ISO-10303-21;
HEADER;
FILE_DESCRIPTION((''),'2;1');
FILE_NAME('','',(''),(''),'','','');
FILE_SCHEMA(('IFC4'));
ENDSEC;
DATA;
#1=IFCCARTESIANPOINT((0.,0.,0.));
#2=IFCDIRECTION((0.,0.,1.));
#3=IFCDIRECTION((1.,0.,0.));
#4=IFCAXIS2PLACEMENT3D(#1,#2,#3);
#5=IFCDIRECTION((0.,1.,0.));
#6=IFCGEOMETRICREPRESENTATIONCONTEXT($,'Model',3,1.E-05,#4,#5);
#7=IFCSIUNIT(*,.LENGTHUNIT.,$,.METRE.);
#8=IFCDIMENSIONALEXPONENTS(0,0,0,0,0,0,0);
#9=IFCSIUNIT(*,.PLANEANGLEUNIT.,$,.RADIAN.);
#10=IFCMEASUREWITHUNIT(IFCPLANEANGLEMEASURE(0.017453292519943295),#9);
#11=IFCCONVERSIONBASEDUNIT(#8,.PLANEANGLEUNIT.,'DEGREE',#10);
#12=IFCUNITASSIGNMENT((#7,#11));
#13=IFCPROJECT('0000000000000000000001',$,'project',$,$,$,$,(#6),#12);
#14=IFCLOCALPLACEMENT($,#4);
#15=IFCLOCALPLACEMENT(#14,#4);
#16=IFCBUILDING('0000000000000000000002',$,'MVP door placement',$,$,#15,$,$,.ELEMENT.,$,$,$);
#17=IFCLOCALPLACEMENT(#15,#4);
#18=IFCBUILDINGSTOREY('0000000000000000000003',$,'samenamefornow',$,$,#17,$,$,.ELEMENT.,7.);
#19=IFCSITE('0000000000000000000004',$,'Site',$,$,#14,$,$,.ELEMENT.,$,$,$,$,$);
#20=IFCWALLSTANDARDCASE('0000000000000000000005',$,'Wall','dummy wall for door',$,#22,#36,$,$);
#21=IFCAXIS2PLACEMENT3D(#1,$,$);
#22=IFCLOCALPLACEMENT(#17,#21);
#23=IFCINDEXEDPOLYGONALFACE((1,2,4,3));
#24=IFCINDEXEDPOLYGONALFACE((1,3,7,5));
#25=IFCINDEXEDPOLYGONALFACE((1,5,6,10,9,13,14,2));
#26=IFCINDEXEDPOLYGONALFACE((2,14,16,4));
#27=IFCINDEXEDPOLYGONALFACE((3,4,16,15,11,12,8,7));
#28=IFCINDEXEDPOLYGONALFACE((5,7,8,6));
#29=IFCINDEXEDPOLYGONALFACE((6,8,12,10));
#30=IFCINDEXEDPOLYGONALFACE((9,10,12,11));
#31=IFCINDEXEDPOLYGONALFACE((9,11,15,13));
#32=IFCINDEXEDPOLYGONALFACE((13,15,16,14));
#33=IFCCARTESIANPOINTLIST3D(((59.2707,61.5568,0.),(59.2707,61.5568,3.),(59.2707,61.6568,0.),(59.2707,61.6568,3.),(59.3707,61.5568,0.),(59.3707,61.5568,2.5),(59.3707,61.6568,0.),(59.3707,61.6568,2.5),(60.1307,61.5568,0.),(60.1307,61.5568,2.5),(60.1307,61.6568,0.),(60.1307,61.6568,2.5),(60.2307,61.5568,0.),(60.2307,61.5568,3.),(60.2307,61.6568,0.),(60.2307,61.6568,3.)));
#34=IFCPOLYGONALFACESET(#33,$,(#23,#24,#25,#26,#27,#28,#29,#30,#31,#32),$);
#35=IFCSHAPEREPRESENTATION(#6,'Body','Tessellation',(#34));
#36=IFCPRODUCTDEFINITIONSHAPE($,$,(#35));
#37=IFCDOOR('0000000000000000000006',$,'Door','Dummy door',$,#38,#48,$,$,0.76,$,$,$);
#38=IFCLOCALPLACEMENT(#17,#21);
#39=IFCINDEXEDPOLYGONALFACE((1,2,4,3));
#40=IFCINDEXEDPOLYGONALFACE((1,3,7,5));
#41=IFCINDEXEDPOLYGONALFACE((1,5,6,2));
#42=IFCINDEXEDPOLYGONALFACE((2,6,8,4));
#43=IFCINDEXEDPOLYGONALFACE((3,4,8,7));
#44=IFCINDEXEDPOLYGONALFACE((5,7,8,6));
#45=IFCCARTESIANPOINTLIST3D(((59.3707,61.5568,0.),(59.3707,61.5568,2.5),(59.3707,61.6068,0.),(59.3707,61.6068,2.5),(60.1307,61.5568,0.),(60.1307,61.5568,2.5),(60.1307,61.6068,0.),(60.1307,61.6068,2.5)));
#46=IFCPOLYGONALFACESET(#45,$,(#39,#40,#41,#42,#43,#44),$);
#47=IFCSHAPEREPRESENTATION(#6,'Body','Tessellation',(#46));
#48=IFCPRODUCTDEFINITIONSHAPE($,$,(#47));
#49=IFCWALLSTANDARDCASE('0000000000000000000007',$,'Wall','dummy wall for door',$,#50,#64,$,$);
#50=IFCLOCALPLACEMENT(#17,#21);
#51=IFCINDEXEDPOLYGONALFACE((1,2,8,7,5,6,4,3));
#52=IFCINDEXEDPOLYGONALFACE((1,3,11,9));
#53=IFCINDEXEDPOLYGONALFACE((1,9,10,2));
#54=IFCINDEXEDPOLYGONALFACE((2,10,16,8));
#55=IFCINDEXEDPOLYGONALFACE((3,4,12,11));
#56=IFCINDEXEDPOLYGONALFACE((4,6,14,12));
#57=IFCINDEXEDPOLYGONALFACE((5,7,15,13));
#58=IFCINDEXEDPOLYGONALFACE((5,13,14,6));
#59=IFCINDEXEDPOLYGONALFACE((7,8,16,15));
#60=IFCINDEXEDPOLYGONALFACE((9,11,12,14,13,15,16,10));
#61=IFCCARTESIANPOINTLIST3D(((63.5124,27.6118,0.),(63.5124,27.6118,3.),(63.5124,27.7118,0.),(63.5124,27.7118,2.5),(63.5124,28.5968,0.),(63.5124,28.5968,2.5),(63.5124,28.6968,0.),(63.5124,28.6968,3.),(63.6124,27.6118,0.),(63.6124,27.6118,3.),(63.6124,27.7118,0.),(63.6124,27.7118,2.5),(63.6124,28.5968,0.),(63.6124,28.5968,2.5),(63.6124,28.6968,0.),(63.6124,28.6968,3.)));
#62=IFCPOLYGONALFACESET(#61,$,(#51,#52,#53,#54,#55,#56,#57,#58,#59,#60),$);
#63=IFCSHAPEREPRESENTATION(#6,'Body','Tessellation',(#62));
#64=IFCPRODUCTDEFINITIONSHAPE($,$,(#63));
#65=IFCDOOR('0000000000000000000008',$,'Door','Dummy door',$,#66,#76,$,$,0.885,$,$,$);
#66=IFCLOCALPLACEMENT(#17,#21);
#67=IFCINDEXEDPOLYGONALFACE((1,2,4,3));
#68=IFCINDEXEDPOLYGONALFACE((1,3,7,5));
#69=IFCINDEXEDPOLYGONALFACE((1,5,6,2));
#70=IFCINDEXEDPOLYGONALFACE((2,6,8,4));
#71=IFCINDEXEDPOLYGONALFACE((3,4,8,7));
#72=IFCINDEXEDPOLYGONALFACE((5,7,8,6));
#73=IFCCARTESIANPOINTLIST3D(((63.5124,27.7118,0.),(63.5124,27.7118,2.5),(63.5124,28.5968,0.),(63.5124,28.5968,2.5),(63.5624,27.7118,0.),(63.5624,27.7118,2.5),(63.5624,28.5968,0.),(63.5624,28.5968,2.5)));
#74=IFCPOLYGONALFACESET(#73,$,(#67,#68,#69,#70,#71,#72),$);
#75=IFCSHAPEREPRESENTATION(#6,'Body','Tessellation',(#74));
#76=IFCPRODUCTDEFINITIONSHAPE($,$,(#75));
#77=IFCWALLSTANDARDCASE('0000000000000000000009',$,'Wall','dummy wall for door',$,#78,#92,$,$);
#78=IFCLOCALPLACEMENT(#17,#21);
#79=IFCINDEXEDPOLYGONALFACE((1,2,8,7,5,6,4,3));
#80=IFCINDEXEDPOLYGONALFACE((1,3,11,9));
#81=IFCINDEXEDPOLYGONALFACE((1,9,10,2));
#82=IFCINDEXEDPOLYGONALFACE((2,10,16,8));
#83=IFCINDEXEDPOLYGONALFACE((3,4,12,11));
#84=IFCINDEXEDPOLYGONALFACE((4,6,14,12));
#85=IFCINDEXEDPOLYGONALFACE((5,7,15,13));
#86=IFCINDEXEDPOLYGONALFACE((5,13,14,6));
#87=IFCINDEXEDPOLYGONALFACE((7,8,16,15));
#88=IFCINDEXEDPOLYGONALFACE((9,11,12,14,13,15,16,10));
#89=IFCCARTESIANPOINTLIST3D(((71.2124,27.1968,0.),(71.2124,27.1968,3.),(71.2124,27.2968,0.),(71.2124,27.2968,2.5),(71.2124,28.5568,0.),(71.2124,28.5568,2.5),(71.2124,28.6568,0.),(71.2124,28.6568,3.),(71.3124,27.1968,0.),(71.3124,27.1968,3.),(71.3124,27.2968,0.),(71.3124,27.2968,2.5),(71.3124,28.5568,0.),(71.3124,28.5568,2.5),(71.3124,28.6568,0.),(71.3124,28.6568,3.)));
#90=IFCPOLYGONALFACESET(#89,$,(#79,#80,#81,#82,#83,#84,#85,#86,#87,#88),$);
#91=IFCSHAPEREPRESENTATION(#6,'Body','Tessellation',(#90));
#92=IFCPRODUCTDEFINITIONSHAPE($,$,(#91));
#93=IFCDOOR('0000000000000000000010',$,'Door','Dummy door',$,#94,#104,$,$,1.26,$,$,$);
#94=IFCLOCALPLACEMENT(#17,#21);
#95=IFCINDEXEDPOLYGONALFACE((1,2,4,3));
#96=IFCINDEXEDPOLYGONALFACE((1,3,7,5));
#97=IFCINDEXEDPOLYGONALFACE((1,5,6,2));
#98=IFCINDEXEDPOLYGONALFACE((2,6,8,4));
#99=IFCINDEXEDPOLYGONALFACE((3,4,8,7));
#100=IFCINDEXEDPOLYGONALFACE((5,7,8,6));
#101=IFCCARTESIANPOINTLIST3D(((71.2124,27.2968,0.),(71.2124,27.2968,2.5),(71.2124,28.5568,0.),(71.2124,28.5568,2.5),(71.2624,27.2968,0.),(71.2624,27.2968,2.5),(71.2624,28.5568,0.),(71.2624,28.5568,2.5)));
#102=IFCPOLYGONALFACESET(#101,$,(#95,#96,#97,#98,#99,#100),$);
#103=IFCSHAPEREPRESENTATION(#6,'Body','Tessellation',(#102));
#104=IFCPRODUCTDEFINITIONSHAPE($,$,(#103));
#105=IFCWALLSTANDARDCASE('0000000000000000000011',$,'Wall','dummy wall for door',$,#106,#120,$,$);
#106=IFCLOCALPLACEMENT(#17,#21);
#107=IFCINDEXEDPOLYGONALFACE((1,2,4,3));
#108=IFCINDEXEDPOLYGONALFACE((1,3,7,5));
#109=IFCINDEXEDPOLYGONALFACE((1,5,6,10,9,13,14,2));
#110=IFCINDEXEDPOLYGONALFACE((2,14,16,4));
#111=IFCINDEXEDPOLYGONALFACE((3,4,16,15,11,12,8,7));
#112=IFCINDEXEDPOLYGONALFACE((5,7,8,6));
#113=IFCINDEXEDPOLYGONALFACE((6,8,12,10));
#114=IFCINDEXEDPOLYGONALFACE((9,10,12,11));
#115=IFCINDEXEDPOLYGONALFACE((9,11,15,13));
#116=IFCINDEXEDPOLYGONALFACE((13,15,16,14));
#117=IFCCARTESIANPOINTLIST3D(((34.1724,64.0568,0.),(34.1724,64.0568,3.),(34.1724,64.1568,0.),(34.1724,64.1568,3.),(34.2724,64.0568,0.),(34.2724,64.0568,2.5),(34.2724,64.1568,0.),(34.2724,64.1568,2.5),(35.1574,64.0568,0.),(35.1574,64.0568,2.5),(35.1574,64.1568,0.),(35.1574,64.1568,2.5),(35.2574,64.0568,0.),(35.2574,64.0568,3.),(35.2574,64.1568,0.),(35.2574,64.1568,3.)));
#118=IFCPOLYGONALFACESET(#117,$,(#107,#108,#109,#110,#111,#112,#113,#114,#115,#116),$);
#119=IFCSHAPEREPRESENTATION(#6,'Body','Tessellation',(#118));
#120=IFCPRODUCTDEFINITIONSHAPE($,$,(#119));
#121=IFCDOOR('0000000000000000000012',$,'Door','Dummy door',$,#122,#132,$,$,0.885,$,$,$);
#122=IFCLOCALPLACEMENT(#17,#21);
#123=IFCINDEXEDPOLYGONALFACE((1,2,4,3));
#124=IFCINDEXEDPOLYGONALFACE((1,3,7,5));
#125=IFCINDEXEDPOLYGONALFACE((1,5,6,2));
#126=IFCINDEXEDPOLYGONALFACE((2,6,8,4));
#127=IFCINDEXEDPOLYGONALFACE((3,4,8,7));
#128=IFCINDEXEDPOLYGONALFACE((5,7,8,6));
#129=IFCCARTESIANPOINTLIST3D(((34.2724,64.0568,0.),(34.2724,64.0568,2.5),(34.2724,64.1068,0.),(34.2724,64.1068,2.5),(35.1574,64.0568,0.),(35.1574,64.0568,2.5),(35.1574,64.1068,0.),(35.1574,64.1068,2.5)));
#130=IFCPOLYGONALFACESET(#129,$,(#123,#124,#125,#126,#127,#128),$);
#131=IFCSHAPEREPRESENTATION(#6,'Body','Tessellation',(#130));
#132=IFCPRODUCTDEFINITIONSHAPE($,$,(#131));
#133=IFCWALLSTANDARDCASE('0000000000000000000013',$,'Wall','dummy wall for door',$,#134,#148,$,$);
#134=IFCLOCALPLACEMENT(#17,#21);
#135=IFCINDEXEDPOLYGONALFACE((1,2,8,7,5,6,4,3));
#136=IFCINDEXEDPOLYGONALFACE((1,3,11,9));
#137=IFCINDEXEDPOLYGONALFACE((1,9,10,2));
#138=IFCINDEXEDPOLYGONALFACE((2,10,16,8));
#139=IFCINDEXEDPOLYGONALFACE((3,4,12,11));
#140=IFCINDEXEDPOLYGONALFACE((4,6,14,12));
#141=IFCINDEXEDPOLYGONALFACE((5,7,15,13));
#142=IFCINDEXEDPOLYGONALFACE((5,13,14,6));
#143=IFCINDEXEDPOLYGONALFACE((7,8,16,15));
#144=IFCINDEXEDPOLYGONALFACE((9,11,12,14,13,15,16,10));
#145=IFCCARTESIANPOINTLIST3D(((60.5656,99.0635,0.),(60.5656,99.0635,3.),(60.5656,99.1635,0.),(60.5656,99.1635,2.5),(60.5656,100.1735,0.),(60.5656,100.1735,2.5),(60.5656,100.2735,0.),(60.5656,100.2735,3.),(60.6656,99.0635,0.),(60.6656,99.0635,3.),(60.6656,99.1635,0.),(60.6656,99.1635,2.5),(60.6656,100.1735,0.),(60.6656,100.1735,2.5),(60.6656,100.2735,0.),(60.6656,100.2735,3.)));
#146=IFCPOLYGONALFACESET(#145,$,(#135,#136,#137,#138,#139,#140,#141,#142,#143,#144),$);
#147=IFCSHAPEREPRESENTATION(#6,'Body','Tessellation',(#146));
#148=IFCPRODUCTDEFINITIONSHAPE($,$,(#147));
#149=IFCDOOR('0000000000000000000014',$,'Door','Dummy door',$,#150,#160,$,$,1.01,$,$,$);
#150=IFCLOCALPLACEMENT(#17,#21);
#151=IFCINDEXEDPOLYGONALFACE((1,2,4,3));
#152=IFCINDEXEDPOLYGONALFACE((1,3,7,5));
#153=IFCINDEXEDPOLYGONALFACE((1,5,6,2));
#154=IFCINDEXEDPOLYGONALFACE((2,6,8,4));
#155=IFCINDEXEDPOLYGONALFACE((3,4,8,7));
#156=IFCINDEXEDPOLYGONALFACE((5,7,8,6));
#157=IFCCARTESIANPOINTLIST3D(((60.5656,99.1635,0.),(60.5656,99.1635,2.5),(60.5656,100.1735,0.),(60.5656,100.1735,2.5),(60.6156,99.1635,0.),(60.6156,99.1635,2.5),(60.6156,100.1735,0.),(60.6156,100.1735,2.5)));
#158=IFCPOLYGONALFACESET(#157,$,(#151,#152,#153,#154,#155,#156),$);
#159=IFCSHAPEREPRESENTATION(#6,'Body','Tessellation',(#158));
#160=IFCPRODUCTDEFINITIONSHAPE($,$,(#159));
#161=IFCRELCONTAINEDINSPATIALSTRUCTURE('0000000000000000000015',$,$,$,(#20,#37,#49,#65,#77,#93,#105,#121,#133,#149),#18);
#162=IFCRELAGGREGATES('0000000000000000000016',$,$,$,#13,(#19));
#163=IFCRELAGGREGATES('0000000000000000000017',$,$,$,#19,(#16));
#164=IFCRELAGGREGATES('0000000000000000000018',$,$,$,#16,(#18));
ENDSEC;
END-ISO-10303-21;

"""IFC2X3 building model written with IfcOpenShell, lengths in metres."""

from ifc_helpers import new_model, entity, si_unit, converted_unit, direction, origin_with_axes, place, context, project, spatial, polyline, outline, extrude, element, fill, save


model = new_model("IFC2X3")

# Units and contexts
model_context = context("Model", 3, precision=1e-05, world=origin_with_axes(), true_north=direction((0.0, 1.0, 0.0)))
ifc_project = project(units=[si_unit("LENGTHUNIT", "METRE"), converted_unit("PLANEANGLEUNIT", "DEGREE", entity("IfcPlaneAngleMeasure", 0.017453292519943295), si_unit("PLANEANGLEUNIT", "RADIAN"), dimensions=[0, 0, 0, 0, 0, 0, 0])], contexts=[model_context])

# Site, building, storey
site_placement = place(None, origin_with_axes())
site = spatial("IfcSite", under=ifc_project, at=site_placement, Name="Site", CompositionType="ELEMENT")
building_placement = place(site_placement, origin_with_axes())
building = spatial("IfcBuilding", under=site, at=building_placement, Name="MVP door placement", CompositionType="ELEMENT")
storey_placement = place(building_placement, origin_with_axes())
storey = spatial("IfcBuildingStorey", under=building, at=storey_placement, Name="samenamefornow", CompositionType="ELEMENT", Elevation=7.0)

# Walls, openings, doors
wall_1_placement = place(storey_placement, origin_with_axes())
wall_1 = element("IfcWallStandardCase", 1, at=wall_1_placement, inside=storey, Name="Wall", Description="dummy wall for door", context=model_context, shape_type="SweptSolid", body=[
    extrude(outline(polyline([(60.2307, 61.5568, 0.0), (59.2707, 61.5568, 0.0), (59.2707, 61.6568, 0.0), (60.2307, 61.6568, 0.0), (60.2307, 61.5568, 0.0)])), origin_with_axes(), (0.0, 0.0, 1.0), 3.0),
])
opening_1_placement = place(wall_1_placement, origin_with_axes())
opening_1 = element("IfcOpeningElement", 2, at=opening_1_placement, cuts=wall_1, context=model_context, shape_type="SweptSolid", body=[
    extrude(outline(polyline([(60.1307, 61.5568, 0.0), (59.3707, 61.5568, 0.0), (59.3707, 61.6568, 0.0), (60.1307, 61.6568, 0.0), (60.1307, 61.5568, 0.0)])), origin_with_axes(), (0.0, 0.0, 1.0), 2.5),
])
door_1_placement = place(opening_1_placement, origin_with_axes())
door_1 = element("IfcDoor", 3, at=door_1_placement, inside=storey, Name="Door", Description="Dummy door", OverallWidth=0.76, context=model_context, shape_type="SweptSolid", body=[
    extrude(outline(polyline([(60.1307, 61.5568, 0.0), (59.3707, 61.5568, 0.0), (59.3707, 61.6068, 0.0), (60.1307, 61.6068, 0.0), (60.1307, 61.5568, 0.0)])), origin_with_axes(), (0.0, 0.0, 1.0), 2.5),
])
fill(opening_1, door_1)
wall_2_placement = place(storey_placement, origin_with_axes())
wall_2 = element("IfcWallStandardCase", 4, at=wall_2_placement, inside=storey, Name="Wall", Description="dummy wall for door", context=model_context, shape_type="SweptSolid", body=[
    extrude(outline(polyline([(63.5124, 27.6118, 0.0), (63.5124, 28.6968, 0.0), (63.6124, 28.6968, 0.0), (63.6124, 27.6118, 0.0), (63.5124, 27.6118, 0.0)])), origin_with_axes(), (0.0, 0.0, 1.0), 3.0),
])
opening_2_placement = place(wall_2_placement, origin_with_axes())
opening_2 = element("IfcOpeningElement", 5, at=opening_2_placement, cuts=wall_2, context=model_context, shape_type="SweptSolid", body=[
    extrude(outline(polyline([(63.5124, 27.7118, 0.0), (63.5124, 28.5968, 0.0), (63.6124, 28.5968, 0.0), (63.6124, 27.7118, 0.0), (63.5124, 27.7118, 0.0)])), origin_with_axes(), (0.0, 0.0, 1.0), 2.5),
])
door_2_placement = place(opening_2_placement, origin_with_axes())
door_2 = element("IfcDoor", 6, at=door_2_placement, inside=storey, Name="Door", Description="Dummy door", OverallWidth=0.885, context=model_context, shape_type="SweptSolid", body=[
    extrude(outline(polyline([(63.5124, 27.7118, 0.0), (63.5124, 28.5968, 0.0), (63.5624, 28.5968, 0.0), (63.5624, 27.7118, 0.0), (63.5124, 27.7118, 0.0)])), origin_with_axes(), (0.0, 0.0, 1.0), 2.5),
])
fill(opening_2, door_2)
wall_3_placement = place(storey_placement, origin_with_axes())
wall_3 = element("IfcWallStandardCase", 7, at=wall_3_placement, inside=storey, Name="Wall", Description="dummy wall for door", context=model_context, shape_type="SweptSolid", body=[
    extrude(outline(polyline([(71.2124, 28.6568, 0.0), (71.2124, 27.1968, 0.0), (71.3124, 27.1968, 0.0), (71.3124, 28.6568, 0.0), (71.2124, 28.6568, 0.0)])), origin_with_axes(), (0.0, 0.0, 1.0), 3.0),
])
opening_3_placement = place(wall_3_placement, origin_with_axes())
opening_3 = element("IfcOpeningElement", 8, at=opening_3_placement, cuts=wall_3, context=model_context, shape_type="SweptSolid", body=[
    extrude(outline(polyline([(71.2124, 28.5568, 0.0), (71.2124, 27.2968, 0.0), (71.3124, 27.2968, 0.0), (71.3124, 28.5568, 0.0), (71.2124, 28.5568, 0.0)])), origin_with_axes(), (0.0, 0.0, 1.0), 2.5),
])
door_3_placement = place(opening_3_placement, origin_with_axes())
door_3 = element("IfcDoor", 9, at=door_3_placement, inside=storey, Name="Door", Description="Dummy door", OverallWidth=1.26, context=model_context, shape_type="SweptSolid", body=[
    extrude(outline(polyline([(71.2124, 28.5568, 0.0), (71.2124, 27.2968, 0.0), (71.2624, 27.2968, 0.0), (71.2624, 28.5568, 0.0), (71.2124, 28.5568, 0.0)])), origin_with_axes(), (0.0, 0.0, 1.0), 2.5),
])
fill(opening_3, door_3)
wall_4_placement = place(storey_placement, origin_with_axes())
wall_4 = element("IfcWallStandardCase", 10, at=wall_4_placement, inside=storey, Name="Wall", Description="dummy wall for door", context=model_context, shape_type="SweptSolid", body=[
    extrude(outline(polyline([(35.2574, 64.0568, 0.0), (34.1724, 64.0568, 0.0), (34.1724, 64.1568, 0.0), (35.2574, 64.1568, 0.0), (35.2574, 64.0568, 0.0)])), origin_with_axes(), (0.0, 0.0, 1.0), 3.0),
])
opening_4_placement = place(wall_4_placement, origin_with_axes())
opening_4 = element("IfcOpeningElement", 11, at=opening_4_placement, cuts=wall_4, context=model_context, shape_type="SweptSolid", body=[
    extrude(outline(polyline([(35.1574, 64.0568, 0.0), (34.2724, 64.0568, 0.0), (34.2724, 64.1568, 0.0), (35.1574, 64.1568, 0.0), (35.1574, 64.0568, 0.0)])), origin_with_axes(), (0.0, 0.0, 1.0), 2.5),
])
door_4_placement = place(opening_4_placement, origin_with_axes())
door_4 = element("IfcDoor", 12, at=door_4_placement, inside=storey, Name="Door", Description="Dummy door", OverallWidth=0.885, context=model_context, shape_type="SweptSolid", body=[
    extrude(outline(polyline([(35.1574, 64.0568, 0.0), (34.2724, 64.0568, 0.0), (34.2724, 64.1068, 0.0), (35.1574, 64.1068, 0.0), (35.1574, 64.0568, 0.0)])), origin_with_axes(), (0.0, 0.0, 1.0), 2.5),
])
fill(opening_4, door_4)
wall_5_placement = place(storey_placement, origin_with_axes())
wall_5 = element("IfcWallStandardCase", 13, at=wall_5_placement, inside=storey, Name="Wall", Description="dummy wall for door", context=model_context, shape_type="SweptSolid", body=[
    extrude(outline(polyline([(60.5656, 100.2735, 0.0), (60.5656, 99.0635, 0.0), (60.6656, 99.0635, 0.0), (60.6656, 100.2735, 0.0), (60.5656, 100.2735, 0.0)])), origin_with_axes(), (0.0, 0.0, 1.0), 3.0),
])
opening_5_placement = place(wall_5_placement, origin_with_axes())
opening_5 = element("IfcOpeningElement", 14, at=opening_5_placement, cuts=wall_5, context=model_context, shape_type="SweptSolid", body=[
    extrude(outline(polyline([(60.5656, 100.1735, 0.0), (60.5656, 99.1635, 0.0), (60.6656, 99.1635, 0.0), (60.6656, 100.1735, 0.0), (60.5656, 100.1735, 0.0)])), origin_with_axes(), (0.0, 0.0, 1.0), 2.5),
])
door_5_placement = place(opening_5_placement, origin_with_axes())
door_5 = element("IfcDoor", 15, at=door_5_placement, inside=storey, Name="Door", Description="Dummy door", OverallWidth=1.01, context=model_context, shape_type="SweptSolid", body=[
    extrude(outline(polyline([(60.5656, 100.1735, 0.0), (60.5656, 99.1635, 0.0), (60.6156, 99.1635, 0.0), (60.6156, 100.1735, 0.0), (60.5656, 100.1735, 0.0)])), origin_with_axes(), (0.0, 0.0, 1.0), 2.5),
])
fill(opening_5, door_5)

save(model, "model.ifc")
